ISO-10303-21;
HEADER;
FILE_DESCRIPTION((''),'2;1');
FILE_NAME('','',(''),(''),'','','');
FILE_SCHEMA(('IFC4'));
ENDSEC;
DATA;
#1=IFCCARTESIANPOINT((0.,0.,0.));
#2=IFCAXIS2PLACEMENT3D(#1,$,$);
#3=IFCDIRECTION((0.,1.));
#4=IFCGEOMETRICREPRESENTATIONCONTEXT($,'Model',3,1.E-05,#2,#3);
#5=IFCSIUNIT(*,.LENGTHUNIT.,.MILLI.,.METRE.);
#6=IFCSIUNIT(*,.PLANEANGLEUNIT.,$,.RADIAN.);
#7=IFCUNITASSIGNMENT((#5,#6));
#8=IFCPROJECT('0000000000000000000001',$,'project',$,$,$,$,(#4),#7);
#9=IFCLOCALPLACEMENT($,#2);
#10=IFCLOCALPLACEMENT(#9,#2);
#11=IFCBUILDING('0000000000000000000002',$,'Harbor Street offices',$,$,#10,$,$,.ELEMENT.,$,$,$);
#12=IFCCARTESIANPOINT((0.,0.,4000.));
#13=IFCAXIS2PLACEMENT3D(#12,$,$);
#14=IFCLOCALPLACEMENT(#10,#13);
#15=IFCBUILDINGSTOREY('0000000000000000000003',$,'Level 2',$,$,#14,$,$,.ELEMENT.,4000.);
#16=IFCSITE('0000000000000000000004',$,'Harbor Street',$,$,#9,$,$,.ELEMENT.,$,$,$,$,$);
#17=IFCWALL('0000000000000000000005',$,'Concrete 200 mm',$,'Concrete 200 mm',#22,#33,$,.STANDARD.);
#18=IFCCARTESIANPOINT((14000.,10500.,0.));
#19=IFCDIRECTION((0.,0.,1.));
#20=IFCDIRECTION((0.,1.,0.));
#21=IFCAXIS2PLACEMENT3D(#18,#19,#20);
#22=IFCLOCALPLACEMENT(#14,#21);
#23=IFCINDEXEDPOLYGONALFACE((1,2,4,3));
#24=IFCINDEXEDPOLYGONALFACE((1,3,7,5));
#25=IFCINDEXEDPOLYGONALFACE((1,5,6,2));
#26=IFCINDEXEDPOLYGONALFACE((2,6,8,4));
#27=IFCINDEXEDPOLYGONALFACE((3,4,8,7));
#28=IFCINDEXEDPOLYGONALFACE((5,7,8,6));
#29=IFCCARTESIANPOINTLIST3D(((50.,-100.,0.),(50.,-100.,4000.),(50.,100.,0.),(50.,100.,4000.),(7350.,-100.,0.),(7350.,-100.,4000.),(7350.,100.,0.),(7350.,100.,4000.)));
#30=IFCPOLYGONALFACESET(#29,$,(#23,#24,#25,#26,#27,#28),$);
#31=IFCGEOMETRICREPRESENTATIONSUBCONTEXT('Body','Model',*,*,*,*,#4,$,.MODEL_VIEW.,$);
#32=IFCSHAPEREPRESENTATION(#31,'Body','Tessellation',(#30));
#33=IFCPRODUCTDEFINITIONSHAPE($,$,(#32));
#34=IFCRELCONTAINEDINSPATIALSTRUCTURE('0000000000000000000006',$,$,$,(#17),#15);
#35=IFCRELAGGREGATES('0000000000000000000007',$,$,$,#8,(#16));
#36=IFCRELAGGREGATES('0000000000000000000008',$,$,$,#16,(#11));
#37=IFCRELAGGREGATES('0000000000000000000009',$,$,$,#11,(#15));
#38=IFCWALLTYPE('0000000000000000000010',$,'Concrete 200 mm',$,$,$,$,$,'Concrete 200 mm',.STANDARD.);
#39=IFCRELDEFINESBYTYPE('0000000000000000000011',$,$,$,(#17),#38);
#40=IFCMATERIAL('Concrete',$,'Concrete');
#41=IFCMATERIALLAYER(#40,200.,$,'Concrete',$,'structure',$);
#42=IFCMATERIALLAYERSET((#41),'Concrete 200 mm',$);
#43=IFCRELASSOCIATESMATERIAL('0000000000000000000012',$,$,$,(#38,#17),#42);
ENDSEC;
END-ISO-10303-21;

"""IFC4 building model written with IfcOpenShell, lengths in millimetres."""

from ifc_helpers import new_model, si_unit, direction, frame, origin, place, context, subcontext, project, spatial, polyline, outline, extrude, material, layer, layer_set, layer_usage, type_object, element, save


model = new_model("IFC4")

# Units and contexts
model_context = context("Model", 3, precision=1e-05, world=origin(), true_north=direction((0.0, 1.0)))
body_context = subcontext(model_context, "Body", "Model", "MODEL_VIEW")
ifc_project = project(units=[si_unit("LENGTHUNIT", "METRE", prefix="MILLI"), si_unit("PLANEANGLEUNIT", "RADIAN")], contexts=[model_context])

# Site, building, storey
site_placement = place(None, origin())
site = spatial("IfcSite", under=ifc_project, at=site_placement, Name="Harbor Street", CompositionType="ELEMENT")
building_placement = place(site_placement, origin())
building = spatial("IfcBuilding", under=site, at=building_placement, Name="Harbor Street offices", CompositionType="ELEMENT")
storey_placement = place(building_placement, frame((0.0, 0.0, 4000.0)))
storey = spatial("IfcBuildingStorey", under=building, at=storey_placement, Name="Level 2", CompositionType="ELEMENT", Elevation=4000.0)

# Shared definitions
ifc_material_1 = material(Name="Concrete", Category="Concrete")

# Wall
ifc_layer_1 = layer(ifc_material_1, 200.0, Name="Concrete", Category="structure")
ifc_layer_set_1 = layer_set([ifc_layer_1], Name="Concrete 200 mm")
ifc_layer_usage_1 = layer_usage(ifc_layer_set_1, "AXIS2", "NEGATIVE", 100.0)
wall_type_1 = type_object("IfcWallType", Name="Concrete 200 mm", ElementType="Concrete 200 mm", PredefinedType="STANDARD", material=ifc_layer_set_1)
wall_1_placement = place(storey_placement, frame((14000.0, 10500.0, 0.0), z_axis=(0.0, 0.0, 1.0), x_axis=(0.0, 1.0, 0.0)))
element("IfcWall", 1, at=wall_1_placement, inside=storey, type_object=wall_type_1, material=ifc_layer_usage_1, Name="Concrete 200 mm", ObjectType="Concrete 200 mm", PredefinedType="STANDARD", context=body_context, shape_type="SweptSolid", body=[
    extrude(outline(polyline([(50.0, -100.0), (7350.0, -100.0), (7350.0, 100.0), (50.0, 100.0), (50.0, -100.0)])), origin(), (0.0, 0.0, 1.0), 4000.0),
])

save(model, "model.ifc")
